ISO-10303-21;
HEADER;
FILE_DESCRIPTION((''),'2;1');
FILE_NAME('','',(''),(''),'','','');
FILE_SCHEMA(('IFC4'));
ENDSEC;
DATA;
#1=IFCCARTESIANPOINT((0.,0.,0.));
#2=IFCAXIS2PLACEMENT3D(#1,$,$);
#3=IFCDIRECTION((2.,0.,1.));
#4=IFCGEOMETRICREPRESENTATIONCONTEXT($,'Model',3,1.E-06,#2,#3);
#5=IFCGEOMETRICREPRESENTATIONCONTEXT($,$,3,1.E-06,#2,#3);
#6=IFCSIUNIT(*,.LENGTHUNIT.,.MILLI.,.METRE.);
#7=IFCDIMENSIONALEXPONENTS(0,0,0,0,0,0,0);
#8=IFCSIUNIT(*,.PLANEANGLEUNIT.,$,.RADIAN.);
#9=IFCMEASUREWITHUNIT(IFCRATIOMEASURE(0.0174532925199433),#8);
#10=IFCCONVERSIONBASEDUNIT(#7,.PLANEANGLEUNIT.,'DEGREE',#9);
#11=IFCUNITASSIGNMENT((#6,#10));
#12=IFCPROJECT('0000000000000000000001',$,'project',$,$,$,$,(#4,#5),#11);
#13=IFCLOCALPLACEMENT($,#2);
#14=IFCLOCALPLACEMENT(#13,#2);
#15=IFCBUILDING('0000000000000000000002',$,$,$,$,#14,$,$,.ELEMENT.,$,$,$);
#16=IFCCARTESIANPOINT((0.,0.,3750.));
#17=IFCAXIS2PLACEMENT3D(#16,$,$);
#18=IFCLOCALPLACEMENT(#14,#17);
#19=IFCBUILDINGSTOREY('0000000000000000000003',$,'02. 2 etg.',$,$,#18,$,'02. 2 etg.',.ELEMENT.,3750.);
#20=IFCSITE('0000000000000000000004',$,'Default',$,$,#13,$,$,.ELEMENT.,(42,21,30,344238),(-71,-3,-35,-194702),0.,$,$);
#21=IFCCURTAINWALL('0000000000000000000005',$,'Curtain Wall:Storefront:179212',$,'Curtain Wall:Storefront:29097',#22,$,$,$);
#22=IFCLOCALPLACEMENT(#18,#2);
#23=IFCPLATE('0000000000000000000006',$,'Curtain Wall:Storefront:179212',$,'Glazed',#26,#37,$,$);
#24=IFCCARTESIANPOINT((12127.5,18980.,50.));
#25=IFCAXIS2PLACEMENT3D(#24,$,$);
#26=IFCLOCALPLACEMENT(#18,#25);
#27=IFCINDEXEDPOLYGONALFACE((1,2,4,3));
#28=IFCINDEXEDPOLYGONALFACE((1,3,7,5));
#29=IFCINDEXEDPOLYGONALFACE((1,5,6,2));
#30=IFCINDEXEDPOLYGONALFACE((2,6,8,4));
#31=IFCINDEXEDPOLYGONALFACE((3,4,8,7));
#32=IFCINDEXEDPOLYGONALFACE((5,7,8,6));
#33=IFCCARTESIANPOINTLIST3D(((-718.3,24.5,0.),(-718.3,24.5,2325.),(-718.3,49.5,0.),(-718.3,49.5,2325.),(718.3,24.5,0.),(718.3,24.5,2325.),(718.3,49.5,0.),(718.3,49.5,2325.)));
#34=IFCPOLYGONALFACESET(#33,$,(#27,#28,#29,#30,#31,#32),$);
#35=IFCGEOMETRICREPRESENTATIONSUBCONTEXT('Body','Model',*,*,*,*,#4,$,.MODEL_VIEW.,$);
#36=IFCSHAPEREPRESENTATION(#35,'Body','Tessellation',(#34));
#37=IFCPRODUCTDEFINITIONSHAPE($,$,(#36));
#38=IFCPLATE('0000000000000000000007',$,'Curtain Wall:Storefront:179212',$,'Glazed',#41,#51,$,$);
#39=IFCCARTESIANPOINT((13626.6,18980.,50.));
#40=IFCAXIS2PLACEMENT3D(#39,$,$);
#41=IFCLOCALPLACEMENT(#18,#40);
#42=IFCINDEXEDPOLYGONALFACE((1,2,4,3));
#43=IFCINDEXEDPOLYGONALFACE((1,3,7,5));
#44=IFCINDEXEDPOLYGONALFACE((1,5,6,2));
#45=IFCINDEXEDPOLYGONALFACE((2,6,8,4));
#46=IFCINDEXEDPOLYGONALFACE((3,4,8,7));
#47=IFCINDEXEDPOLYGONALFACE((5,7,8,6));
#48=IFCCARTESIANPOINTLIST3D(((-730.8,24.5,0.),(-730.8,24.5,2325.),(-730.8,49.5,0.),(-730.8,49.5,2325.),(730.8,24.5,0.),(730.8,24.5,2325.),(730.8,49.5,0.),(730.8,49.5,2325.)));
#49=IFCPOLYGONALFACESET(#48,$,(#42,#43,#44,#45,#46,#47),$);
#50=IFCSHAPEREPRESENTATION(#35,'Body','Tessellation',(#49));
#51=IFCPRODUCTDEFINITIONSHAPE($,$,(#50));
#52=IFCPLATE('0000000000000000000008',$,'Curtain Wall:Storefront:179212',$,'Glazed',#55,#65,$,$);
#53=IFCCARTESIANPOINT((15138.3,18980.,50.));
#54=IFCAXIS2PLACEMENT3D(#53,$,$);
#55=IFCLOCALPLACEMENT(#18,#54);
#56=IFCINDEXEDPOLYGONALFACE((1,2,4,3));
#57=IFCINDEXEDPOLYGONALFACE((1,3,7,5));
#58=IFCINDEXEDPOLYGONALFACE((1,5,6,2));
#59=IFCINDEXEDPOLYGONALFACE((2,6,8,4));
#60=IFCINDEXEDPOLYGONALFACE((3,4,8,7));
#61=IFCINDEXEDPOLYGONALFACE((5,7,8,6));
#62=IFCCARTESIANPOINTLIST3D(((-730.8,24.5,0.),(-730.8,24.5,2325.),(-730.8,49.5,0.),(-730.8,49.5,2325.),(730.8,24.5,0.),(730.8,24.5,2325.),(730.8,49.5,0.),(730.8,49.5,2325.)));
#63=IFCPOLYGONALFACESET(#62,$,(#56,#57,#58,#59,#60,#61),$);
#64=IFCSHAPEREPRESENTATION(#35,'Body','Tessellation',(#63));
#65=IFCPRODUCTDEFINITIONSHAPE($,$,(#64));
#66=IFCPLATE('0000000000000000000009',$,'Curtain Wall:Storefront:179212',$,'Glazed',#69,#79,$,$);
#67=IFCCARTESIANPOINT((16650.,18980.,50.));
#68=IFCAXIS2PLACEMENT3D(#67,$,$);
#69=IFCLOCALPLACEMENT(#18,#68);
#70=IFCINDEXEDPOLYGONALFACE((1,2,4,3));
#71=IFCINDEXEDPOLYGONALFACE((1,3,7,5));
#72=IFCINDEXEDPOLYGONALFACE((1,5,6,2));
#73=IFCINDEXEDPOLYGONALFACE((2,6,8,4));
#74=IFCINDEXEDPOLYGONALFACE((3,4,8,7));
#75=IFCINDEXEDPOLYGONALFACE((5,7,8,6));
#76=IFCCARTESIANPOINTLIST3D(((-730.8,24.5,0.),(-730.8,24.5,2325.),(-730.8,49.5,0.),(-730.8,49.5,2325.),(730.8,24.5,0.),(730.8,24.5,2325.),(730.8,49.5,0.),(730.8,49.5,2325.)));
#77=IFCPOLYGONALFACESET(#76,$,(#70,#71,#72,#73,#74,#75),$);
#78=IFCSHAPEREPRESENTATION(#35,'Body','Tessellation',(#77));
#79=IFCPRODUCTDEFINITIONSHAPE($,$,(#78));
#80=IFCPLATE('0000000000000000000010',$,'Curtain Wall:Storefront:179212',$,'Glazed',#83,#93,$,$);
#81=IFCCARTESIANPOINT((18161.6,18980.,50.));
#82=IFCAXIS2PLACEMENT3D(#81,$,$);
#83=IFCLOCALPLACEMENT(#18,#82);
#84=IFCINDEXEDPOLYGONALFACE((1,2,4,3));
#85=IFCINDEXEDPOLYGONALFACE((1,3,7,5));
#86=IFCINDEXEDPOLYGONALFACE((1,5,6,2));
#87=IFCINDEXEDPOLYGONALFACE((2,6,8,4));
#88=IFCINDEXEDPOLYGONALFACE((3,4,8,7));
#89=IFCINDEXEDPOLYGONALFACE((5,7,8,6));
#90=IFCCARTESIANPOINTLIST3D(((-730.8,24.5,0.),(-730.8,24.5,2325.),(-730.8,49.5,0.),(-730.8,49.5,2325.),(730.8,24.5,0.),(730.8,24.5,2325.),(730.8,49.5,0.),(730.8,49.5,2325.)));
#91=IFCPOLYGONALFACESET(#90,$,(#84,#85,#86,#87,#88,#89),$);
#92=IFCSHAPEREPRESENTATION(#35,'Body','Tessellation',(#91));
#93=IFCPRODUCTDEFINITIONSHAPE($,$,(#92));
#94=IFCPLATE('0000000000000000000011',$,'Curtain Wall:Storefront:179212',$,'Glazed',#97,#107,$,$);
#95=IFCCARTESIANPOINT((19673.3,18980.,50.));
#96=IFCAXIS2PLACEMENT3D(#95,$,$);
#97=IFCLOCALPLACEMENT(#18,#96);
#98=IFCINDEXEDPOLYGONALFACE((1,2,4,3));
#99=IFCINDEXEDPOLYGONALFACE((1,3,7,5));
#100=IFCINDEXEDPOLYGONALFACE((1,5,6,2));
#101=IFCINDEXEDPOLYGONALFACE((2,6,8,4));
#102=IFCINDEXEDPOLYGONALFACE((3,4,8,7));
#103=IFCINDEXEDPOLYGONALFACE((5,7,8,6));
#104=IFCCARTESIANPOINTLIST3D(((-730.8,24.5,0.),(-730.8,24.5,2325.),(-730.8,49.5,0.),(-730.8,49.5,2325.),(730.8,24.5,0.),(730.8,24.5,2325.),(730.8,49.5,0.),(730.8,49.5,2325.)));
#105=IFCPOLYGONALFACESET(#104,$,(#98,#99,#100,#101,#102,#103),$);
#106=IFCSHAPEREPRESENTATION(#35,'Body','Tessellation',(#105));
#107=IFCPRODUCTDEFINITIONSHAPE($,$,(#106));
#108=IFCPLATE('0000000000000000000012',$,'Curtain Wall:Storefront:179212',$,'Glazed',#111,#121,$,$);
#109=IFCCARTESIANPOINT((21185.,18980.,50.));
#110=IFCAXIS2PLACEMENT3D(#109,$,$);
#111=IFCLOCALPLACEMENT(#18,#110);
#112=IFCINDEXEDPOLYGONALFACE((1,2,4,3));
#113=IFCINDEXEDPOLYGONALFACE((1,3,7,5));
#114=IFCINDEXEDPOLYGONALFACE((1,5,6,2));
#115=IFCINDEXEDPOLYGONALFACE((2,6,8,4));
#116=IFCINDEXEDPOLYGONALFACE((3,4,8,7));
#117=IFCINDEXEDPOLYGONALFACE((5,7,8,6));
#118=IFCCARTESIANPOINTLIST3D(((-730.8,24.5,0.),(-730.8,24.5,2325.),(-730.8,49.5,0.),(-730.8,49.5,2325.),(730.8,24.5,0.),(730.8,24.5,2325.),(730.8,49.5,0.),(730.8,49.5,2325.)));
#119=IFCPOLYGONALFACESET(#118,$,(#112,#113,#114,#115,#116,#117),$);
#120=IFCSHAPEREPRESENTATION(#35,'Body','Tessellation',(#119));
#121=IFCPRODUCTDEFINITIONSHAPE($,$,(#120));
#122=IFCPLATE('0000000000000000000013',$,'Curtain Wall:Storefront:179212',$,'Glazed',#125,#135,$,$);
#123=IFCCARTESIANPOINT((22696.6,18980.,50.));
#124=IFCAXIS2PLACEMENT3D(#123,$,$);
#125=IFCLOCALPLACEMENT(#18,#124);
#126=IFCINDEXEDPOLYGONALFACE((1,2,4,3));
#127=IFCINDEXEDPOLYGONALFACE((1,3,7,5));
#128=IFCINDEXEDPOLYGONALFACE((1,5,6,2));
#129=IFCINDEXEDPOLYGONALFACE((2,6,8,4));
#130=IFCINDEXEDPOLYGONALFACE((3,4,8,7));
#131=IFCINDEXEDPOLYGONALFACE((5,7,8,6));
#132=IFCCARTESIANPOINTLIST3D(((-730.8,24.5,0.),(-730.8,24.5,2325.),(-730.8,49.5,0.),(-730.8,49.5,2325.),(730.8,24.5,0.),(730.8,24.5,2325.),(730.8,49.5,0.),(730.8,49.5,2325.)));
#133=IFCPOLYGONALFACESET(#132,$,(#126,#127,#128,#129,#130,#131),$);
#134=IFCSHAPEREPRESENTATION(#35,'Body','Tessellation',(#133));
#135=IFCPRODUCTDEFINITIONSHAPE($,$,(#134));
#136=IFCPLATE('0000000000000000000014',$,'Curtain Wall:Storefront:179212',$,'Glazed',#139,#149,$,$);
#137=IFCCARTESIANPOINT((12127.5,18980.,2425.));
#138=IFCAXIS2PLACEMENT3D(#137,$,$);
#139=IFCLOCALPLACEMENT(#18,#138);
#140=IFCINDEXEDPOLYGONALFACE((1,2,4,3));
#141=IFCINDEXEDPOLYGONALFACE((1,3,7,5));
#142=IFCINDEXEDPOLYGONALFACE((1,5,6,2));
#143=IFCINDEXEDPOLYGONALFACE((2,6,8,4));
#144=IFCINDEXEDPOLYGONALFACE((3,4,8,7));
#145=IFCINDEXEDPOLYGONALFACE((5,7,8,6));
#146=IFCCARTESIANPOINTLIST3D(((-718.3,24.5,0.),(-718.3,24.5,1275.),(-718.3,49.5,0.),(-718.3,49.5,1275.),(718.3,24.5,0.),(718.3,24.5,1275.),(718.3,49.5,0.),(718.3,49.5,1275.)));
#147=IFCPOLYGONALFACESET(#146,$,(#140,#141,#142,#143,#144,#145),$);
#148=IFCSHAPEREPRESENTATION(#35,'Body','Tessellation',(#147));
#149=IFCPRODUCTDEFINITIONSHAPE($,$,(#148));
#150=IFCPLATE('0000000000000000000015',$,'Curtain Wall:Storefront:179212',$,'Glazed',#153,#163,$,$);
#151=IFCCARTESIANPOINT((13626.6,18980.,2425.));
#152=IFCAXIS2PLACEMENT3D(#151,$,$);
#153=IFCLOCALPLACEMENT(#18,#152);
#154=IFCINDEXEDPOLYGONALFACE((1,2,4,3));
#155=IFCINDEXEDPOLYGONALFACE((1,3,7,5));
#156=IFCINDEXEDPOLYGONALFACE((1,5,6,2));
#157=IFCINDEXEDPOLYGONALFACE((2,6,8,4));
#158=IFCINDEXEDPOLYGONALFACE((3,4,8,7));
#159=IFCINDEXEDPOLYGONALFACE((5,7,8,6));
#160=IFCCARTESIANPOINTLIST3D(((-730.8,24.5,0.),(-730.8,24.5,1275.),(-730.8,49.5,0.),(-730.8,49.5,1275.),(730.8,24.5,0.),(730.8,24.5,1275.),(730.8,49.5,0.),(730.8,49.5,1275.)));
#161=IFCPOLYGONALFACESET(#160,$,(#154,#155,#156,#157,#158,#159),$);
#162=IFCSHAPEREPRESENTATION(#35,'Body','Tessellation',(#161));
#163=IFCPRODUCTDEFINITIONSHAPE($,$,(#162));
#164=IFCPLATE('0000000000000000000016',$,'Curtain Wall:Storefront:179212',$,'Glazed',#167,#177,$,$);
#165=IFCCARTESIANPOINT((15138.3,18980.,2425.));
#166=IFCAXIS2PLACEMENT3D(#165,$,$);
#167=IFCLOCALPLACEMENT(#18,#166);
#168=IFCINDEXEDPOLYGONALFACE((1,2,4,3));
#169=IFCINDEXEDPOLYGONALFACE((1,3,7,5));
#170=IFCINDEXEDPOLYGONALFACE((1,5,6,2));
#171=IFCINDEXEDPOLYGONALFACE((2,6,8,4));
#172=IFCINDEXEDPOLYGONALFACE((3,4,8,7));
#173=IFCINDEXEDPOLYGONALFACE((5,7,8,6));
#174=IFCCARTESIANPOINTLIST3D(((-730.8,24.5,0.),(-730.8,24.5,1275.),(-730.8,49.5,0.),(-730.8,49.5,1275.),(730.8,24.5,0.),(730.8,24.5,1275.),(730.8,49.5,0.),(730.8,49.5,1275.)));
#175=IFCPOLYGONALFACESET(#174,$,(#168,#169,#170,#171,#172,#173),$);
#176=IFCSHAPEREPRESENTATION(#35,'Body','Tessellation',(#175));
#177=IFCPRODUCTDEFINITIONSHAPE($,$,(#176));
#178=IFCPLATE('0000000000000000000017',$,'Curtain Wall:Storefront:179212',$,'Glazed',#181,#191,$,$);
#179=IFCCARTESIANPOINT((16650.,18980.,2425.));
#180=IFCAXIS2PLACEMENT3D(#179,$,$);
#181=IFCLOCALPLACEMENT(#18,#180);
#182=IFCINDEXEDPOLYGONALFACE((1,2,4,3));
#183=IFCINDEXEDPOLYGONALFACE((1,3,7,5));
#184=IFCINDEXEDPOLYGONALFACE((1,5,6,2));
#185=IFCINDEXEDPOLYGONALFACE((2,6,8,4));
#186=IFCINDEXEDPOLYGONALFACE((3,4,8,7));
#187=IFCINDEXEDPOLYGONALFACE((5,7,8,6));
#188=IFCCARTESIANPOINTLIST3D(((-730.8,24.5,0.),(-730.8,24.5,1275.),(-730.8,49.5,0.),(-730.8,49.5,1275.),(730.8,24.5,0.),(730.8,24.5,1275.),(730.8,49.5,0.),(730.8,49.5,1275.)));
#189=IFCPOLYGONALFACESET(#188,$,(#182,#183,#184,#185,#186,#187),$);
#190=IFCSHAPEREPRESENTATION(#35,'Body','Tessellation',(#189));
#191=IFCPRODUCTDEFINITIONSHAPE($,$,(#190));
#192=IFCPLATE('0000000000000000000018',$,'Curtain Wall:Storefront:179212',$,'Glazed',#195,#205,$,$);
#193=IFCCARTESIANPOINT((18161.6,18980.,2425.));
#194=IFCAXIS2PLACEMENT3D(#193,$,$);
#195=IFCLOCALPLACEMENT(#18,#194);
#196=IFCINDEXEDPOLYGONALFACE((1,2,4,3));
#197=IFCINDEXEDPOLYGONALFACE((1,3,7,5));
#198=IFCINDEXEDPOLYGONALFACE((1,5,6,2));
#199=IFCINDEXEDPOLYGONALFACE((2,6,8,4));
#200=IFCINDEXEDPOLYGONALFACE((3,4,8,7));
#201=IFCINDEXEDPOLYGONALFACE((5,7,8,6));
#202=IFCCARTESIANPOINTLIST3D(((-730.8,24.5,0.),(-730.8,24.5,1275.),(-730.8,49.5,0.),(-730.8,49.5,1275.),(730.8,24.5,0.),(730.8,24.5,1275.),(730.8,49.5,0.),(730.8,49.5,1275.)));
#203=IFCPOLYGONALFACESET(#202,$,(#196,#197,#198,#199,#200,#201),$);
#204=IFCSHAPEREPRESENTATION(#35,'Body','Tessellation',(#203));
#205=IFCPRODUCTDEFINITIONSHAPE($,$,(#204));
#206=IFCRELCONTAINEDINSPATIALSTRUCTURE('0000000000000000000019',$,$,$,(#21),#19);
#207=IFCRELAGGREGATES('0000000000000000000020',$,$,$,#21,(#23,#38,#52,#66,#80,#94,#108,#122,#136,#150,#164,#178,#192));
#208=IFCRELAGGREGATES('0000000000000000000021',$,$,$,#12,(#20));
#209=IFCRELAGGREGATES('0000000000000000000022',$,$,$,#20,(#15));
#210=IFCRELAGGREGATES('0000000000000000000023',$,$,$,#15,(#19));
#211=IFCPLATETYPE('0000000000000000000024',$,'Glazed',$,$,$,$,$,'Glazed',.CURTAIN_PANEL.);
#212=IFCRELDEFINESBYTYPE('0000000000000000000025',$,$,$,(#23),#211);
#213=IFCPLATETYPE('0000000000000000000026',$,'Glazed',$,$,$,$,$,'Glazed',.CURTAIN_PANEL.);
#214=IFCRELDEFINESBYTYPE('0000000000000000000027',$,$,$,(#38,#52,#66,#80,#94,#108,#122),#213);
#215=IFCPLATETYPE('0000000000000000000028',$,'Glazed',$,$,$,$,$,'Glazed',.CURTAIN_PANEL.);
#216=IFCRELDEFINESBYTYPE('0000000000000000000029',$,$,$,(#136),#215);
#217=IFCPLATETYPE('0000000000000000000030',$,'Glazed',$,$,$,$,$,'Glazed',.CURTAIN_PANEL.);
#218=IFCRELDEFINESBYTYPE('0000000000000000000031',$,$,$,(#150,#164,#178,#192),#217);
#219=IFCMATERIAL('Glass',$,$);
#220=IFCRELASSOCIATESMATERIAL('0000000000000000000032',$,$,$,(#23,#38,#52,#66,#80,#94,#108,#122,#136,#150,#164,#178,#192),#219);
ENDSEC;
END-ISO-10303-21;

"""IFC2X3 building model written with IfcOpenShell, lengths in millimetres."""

from ifc_helpers import new_model, entity, si_unit, converted_unit, direction, frame, origin, origin_2d_with_axis, place, context, subcontext, project, spatial, rectangle, extrude, source, transform, mapped, material, type_object, type_shapes, element, aggregate, save


model = new_model("IFC2X3")

# Units and contexts
model_context = context("Model", 3, precision=1e-06, world=origin(), true_north=direction((2.0, 0.0, 1.0)))
context_of_model = context(None, 3, precision=1e-06, world=origin(), true_north=direction((2.0, 0.0, 1.0)))
body_context = subcontext(model_context, "Body", "Model", "MODEL_VIEW")
ifc_project = project(units=[si_unit("LENGTHUNIT", "METRE", prefix="MILLI"), converted_unit("PLANEANGLEUNIT", "DEGREE", entity("IfcRatioMeasure", 0.0174532925199433), si_unit("PLANEANGLEUNIT", "RADIAN"), dimensions=[0, 0, 0, 0, 0, 0, 0])], contexts=[model_context, context_of_model])

# Site, building, storey
site_placement = place(None, origin())
site = spatial("IfcSite", under=ifc_project, at=site_placement, Name="Default", CompositionType="ELEMENT", RefLatitude=(42, 21, 30, 344238), RefLongitude=(-71, -3, -35, -194702), RefElevation=0.0)
building_placement = place(site_placement, origin())
building = spatial("IfcBuilding", under=site, at=building_placement, CompositionType="ELEMENT")
storey_placement = place(building_placement, frame((0.0, 0.0, 3750.0)))
storey = spatial("IfcBuildingStorey", under=building, at=storey_placement, Name="02. 2 etg.", LongName="02. 2 etg.", CompositionType="ELEMENT", Elevation=3750.0)

# Curtain wall, plates
curtain_wall_placement = place(storey_placement, origin())
curtain_wall = element("IfcCurtainWall", 1, at=curtain_wall_placement, inside=storey, Name="Curtain Wall:Storefront:179212", ObjectType="Curtain Wall:Storefront:29097")
ifc_material_1 = material(Name="Glass")
plate_type_1 = type_object("IfcPlateType", Name="Glazed", ElementType="Glazed", PredefinedType="CURTAIN_PANEL")
shared_shape_1 = source(origin(), body_context, "Body", "SweptSolid", [
    extrude(rectangle(XDim=25.0, YDim=1436.7, at=origin_2d_with_axis()), frame((0.0, 37.0, 0.0), z_axis=(0.0, 0.0, 1.0), x_axis=(0.0, 1.0, 0.0)), (0.0, 0.0, 1.0), 2325.0),
])
type_shapes(plate_type_1, [shared_shape_1])
plate_1_placement = place(storey_placement, frame((12127.5, 18980.0, 50.0)))
plate_1 = element("IfcPlate", 2, at=plate_1_placement, type_object=plate_type_1, material=ifc_material_1, Name="Curtain Wall:Storefront:179212", ObjectType="Glazed", context=body_context, shape_type="MappedRepresentation", body=[
    mapped(shared_shape_1, transform((0.0, 0.0, 0.0), scale=1.0)),
])
plate_type_2 = type_object("IfcPlateType", Name="Glazed", ElementType="Glazed", PredefinedType="CURTAIN_PANEL")
shared_shape_2 = source(origin(), body_context, "Body", "SweptSolid", [
    extrude(rectangle(XDim=25.0, YDim=1461.7, at=origin_2d_with_axis()), frame((0.0, 37.0, 0.0), z_axis=(0.0, 0.0, 1.0), x_axis=(0.0, 1.0, 0.0)), (0.0, 0.0, 1.0), 2325.0),
])
type_shapes(plate_type_2, [shared_shape_2])
plate_2_placement = place(storey_placement, frame((13626.6, 18980.0, 50.0)))
plate_2 = element("IfcPlate", 3, at=plate_2_placement, type_object=plate_type_2, material=ifc_material_1, Name="Curtain Wall:Storefront:179212", ObjectType="Glazed", context=body_context, shape_type="MappedRepresentation", body=[
    mapped(shared_shape_2, transform((0.0, 0.0, 0.0), scale=1.0)),
])
plate_3_placement = place(storey_placement, frame((15138.3, 18980.0, 50.0)))
plate_3 = element("IfcPlate", 4, at=plate_3_placement, type_object=plate_type_2, material=ifc_material_1, Name="Curtain Wall:Storefront:179212", ObjectType="Glazed", context=body_context, shape_type="MappedRepresentation", body=[
    mapped(shared_shape_2, transform((0.0, 0.0, 0.0), scale=1.0)),
])
plate_4_placement = place(storey_placement, frame((16650.0, 18980.0, 50.0)))
plate_4 = element("IfcPlate", 5, at=plate_4_placement, type_object=plate_type_2, material=ifc_material_1, Name="Curtain Wall:Storefront:179212", ObjectType="Glazed", context=body_context, shape_type="MappedRepresentation", body=[
    mapped(shared_shape_2, transform((0.0, 0.0, 0.0), scale=1.0)),
])
plate_5_placement = place(storey_placement, frame((18161.6, 18980.0, 50.0)))
plate_5 = element("IfcPlate", 6, at=plate_5_placement, type_object=plate_type_2, material=ifc_material_1, Name="Curtain Wall:Storefront:179212", ObjectType="Glazed", context=body_context, shape_type="MappedRepresentation", body=[
    mapped(shared_shape_2, transform((0.0, 0.0, 0.0), scale=1.0)),
])
plate_6_placement = place(storey_placement, frame((19673.3, 18980.0, 50.0)))
plate_6 = element("IfcPlate", 7, at=plate_6_placement, type_object=plate_type_2, material=ifc_material_1, Name="Curtain Wall:Storefront:179212", ObjectType="Glazed", context=body_context, shape_type="MappedRepresentation", body=[
    mapped(shared_shape_2, transform((0.0, 0.0, 0.0), scale=1.0)),
])
plate_7_placement = place(storey_placement, frame((21185.0, 18980.0, 50.0)))
plate_7 = element("IfcPlate", 8, at=plate_7_placement, type_object=plate_type_2, material=ifc_material_1, Name="Curtain Wall:Storefront:179212", ObjectType="Glazed", context=body_context, shape_type="MappedRepresentation", body=[
    mapped(shared_shape_2, transform((0.0, 0.0, 0.0), scale=1.0)),
])
plate_8_placement = place(storey_placement, frame((22696.6, 18980.0, 50.0)))
plate_8 = element("IfcPlate", 9, at=plate_8_placement, type_object=plate_type_2, material=ifc_material_1, Name="Curtain Wall:Storefront:179212", ObjectType="Glazed", context=body_context, shape_type="MappedRepresentation", body=[
    mapped(shared_shape_2, transform((0.0, 0.0, 0.0), scale=1.0)),
])
plate_type_3 = type_object("IfcPlateType", Name="Glazed", ElementType="Glazed", PredefinedType="CURTAIN_PANEL")
shared_shape_3 = source(origin(), body_context, "Body", "SweptSolid", [
    extrude(rectangle(XDim=25.0, YDim=1436.7, at=origin_2d_with_axis()), frame((0.0, 37.0, 0.0), z_axis=(0.0, 0.0, 1.0), x_axis=(0.0, 1.0, 0.0)), (0.0, 0.0, 1.0), 1275.0),
])
type_shapes(plate_type_3, [shared_shape_3])
plate_9_placement = place(storey_placement, frame((12127.5, 18980.0, 2425.0)))
plate_9 = element("IfcPlate", 10, at=plate_9_placement, type_object=plate_type_3, material=ifc_material_1, Name="Curtain Wall:Storefront:179212", ObjectType="Glazed", context=body_context, shape_type="MappedRepresentation", body=[
    mapped(shared_shape_3, transform((0.0, 0.0, 0.0), scale=1.0)),
])
plate_type_4 = type_object("IfcPlateType", Name="Glazed", ElementType="Glazed", PredefinedType="CURTAIN_PANEL")
shared_shape_4 = source(origin(), body_context, "Body", "SweptSolid", [
    extrude(rectangle(XDim=25.0, YDim=1461.7, at=origin_2d_with_axis()), frame((0.0, 37.0, 0.0), z_axis=(0.0, 0.0, 1.0), x_axis=(0.0, 1.0, 0.0)), (0.0, 0.0, 1.0), 1275.0),
])
type_shapes(plate_type_4, [shared_shape_4])
plate_10_placement = place(storey_placement, frame((13626.6, 18980.0, 2425.0)))
plate_10 = element("IfcPlate", 11, at=plate_10_placement, type_object=plate_type_4, material=ifc_material_1, Name="Curtain Wall:Storefront:179212", ObjectType="Glazed", context=body_context, shape_type="MappedRepresentation", body=[
    mapped(shared_shape_4, transform((0.0, 0.0, 0.0), scale=1.0)),
])
plate_11_placement = place(storey_placement, frame((15138.3, 18980.0, 2425.0)))
plate_11 = element("IfcPlate", 12, at=plate_11_placement, type_object=plate_type_4, material=ifc_material_1, Name="Curtain Wall:Storefront:179212", ObjectType="Glazed", context=body_context, shape_type="MappedRepresentation", body=[
    mapped(shared_shape_4, transform((0.0, 0.0, 0.0), scale=1.0)),
])
plate_12_placement = place(storey_placement, frame((16650.0, 18980.0, 2425.0)))
plate_12 = element("IfcPlate", 13, at=plate_12_placement, type_object=plate_type_4, material=ifc_material_1, Name="Curtain Wall:Storefront:179212", ObjectType="Glazed", context=body_context, shape_type="MappedRepresentation", body=[
    mapped(shared_shape_4, transform((0.0, 0.0, 0.0), scale=1.0)),
])
plate_13_placement = place(storey_placement, frame((18161.6, 18980.0, 2425.0)))
plate_13 = element("IfcPlate", 14, at=plate_13_placement, type_object=plate_type_4, material=ifc_material_1, Name="Curtain Wall:Storefront:179212", ObjectType="Glazed", context=body_context, shape_type="MappedRepresentation", body=[
    mapped(shared_shape_4, transform((0.0, 0.0, 0.0), scale=1.0)),
])
aggregate(curtain_wall, [plate_1, plate_2, plate_3, plate_4, plate_5, plate_6, plate_7, plate_8, plate_9, plate_10, plate_11, plate_12, plate_13])

save(model, "model.ifc")
